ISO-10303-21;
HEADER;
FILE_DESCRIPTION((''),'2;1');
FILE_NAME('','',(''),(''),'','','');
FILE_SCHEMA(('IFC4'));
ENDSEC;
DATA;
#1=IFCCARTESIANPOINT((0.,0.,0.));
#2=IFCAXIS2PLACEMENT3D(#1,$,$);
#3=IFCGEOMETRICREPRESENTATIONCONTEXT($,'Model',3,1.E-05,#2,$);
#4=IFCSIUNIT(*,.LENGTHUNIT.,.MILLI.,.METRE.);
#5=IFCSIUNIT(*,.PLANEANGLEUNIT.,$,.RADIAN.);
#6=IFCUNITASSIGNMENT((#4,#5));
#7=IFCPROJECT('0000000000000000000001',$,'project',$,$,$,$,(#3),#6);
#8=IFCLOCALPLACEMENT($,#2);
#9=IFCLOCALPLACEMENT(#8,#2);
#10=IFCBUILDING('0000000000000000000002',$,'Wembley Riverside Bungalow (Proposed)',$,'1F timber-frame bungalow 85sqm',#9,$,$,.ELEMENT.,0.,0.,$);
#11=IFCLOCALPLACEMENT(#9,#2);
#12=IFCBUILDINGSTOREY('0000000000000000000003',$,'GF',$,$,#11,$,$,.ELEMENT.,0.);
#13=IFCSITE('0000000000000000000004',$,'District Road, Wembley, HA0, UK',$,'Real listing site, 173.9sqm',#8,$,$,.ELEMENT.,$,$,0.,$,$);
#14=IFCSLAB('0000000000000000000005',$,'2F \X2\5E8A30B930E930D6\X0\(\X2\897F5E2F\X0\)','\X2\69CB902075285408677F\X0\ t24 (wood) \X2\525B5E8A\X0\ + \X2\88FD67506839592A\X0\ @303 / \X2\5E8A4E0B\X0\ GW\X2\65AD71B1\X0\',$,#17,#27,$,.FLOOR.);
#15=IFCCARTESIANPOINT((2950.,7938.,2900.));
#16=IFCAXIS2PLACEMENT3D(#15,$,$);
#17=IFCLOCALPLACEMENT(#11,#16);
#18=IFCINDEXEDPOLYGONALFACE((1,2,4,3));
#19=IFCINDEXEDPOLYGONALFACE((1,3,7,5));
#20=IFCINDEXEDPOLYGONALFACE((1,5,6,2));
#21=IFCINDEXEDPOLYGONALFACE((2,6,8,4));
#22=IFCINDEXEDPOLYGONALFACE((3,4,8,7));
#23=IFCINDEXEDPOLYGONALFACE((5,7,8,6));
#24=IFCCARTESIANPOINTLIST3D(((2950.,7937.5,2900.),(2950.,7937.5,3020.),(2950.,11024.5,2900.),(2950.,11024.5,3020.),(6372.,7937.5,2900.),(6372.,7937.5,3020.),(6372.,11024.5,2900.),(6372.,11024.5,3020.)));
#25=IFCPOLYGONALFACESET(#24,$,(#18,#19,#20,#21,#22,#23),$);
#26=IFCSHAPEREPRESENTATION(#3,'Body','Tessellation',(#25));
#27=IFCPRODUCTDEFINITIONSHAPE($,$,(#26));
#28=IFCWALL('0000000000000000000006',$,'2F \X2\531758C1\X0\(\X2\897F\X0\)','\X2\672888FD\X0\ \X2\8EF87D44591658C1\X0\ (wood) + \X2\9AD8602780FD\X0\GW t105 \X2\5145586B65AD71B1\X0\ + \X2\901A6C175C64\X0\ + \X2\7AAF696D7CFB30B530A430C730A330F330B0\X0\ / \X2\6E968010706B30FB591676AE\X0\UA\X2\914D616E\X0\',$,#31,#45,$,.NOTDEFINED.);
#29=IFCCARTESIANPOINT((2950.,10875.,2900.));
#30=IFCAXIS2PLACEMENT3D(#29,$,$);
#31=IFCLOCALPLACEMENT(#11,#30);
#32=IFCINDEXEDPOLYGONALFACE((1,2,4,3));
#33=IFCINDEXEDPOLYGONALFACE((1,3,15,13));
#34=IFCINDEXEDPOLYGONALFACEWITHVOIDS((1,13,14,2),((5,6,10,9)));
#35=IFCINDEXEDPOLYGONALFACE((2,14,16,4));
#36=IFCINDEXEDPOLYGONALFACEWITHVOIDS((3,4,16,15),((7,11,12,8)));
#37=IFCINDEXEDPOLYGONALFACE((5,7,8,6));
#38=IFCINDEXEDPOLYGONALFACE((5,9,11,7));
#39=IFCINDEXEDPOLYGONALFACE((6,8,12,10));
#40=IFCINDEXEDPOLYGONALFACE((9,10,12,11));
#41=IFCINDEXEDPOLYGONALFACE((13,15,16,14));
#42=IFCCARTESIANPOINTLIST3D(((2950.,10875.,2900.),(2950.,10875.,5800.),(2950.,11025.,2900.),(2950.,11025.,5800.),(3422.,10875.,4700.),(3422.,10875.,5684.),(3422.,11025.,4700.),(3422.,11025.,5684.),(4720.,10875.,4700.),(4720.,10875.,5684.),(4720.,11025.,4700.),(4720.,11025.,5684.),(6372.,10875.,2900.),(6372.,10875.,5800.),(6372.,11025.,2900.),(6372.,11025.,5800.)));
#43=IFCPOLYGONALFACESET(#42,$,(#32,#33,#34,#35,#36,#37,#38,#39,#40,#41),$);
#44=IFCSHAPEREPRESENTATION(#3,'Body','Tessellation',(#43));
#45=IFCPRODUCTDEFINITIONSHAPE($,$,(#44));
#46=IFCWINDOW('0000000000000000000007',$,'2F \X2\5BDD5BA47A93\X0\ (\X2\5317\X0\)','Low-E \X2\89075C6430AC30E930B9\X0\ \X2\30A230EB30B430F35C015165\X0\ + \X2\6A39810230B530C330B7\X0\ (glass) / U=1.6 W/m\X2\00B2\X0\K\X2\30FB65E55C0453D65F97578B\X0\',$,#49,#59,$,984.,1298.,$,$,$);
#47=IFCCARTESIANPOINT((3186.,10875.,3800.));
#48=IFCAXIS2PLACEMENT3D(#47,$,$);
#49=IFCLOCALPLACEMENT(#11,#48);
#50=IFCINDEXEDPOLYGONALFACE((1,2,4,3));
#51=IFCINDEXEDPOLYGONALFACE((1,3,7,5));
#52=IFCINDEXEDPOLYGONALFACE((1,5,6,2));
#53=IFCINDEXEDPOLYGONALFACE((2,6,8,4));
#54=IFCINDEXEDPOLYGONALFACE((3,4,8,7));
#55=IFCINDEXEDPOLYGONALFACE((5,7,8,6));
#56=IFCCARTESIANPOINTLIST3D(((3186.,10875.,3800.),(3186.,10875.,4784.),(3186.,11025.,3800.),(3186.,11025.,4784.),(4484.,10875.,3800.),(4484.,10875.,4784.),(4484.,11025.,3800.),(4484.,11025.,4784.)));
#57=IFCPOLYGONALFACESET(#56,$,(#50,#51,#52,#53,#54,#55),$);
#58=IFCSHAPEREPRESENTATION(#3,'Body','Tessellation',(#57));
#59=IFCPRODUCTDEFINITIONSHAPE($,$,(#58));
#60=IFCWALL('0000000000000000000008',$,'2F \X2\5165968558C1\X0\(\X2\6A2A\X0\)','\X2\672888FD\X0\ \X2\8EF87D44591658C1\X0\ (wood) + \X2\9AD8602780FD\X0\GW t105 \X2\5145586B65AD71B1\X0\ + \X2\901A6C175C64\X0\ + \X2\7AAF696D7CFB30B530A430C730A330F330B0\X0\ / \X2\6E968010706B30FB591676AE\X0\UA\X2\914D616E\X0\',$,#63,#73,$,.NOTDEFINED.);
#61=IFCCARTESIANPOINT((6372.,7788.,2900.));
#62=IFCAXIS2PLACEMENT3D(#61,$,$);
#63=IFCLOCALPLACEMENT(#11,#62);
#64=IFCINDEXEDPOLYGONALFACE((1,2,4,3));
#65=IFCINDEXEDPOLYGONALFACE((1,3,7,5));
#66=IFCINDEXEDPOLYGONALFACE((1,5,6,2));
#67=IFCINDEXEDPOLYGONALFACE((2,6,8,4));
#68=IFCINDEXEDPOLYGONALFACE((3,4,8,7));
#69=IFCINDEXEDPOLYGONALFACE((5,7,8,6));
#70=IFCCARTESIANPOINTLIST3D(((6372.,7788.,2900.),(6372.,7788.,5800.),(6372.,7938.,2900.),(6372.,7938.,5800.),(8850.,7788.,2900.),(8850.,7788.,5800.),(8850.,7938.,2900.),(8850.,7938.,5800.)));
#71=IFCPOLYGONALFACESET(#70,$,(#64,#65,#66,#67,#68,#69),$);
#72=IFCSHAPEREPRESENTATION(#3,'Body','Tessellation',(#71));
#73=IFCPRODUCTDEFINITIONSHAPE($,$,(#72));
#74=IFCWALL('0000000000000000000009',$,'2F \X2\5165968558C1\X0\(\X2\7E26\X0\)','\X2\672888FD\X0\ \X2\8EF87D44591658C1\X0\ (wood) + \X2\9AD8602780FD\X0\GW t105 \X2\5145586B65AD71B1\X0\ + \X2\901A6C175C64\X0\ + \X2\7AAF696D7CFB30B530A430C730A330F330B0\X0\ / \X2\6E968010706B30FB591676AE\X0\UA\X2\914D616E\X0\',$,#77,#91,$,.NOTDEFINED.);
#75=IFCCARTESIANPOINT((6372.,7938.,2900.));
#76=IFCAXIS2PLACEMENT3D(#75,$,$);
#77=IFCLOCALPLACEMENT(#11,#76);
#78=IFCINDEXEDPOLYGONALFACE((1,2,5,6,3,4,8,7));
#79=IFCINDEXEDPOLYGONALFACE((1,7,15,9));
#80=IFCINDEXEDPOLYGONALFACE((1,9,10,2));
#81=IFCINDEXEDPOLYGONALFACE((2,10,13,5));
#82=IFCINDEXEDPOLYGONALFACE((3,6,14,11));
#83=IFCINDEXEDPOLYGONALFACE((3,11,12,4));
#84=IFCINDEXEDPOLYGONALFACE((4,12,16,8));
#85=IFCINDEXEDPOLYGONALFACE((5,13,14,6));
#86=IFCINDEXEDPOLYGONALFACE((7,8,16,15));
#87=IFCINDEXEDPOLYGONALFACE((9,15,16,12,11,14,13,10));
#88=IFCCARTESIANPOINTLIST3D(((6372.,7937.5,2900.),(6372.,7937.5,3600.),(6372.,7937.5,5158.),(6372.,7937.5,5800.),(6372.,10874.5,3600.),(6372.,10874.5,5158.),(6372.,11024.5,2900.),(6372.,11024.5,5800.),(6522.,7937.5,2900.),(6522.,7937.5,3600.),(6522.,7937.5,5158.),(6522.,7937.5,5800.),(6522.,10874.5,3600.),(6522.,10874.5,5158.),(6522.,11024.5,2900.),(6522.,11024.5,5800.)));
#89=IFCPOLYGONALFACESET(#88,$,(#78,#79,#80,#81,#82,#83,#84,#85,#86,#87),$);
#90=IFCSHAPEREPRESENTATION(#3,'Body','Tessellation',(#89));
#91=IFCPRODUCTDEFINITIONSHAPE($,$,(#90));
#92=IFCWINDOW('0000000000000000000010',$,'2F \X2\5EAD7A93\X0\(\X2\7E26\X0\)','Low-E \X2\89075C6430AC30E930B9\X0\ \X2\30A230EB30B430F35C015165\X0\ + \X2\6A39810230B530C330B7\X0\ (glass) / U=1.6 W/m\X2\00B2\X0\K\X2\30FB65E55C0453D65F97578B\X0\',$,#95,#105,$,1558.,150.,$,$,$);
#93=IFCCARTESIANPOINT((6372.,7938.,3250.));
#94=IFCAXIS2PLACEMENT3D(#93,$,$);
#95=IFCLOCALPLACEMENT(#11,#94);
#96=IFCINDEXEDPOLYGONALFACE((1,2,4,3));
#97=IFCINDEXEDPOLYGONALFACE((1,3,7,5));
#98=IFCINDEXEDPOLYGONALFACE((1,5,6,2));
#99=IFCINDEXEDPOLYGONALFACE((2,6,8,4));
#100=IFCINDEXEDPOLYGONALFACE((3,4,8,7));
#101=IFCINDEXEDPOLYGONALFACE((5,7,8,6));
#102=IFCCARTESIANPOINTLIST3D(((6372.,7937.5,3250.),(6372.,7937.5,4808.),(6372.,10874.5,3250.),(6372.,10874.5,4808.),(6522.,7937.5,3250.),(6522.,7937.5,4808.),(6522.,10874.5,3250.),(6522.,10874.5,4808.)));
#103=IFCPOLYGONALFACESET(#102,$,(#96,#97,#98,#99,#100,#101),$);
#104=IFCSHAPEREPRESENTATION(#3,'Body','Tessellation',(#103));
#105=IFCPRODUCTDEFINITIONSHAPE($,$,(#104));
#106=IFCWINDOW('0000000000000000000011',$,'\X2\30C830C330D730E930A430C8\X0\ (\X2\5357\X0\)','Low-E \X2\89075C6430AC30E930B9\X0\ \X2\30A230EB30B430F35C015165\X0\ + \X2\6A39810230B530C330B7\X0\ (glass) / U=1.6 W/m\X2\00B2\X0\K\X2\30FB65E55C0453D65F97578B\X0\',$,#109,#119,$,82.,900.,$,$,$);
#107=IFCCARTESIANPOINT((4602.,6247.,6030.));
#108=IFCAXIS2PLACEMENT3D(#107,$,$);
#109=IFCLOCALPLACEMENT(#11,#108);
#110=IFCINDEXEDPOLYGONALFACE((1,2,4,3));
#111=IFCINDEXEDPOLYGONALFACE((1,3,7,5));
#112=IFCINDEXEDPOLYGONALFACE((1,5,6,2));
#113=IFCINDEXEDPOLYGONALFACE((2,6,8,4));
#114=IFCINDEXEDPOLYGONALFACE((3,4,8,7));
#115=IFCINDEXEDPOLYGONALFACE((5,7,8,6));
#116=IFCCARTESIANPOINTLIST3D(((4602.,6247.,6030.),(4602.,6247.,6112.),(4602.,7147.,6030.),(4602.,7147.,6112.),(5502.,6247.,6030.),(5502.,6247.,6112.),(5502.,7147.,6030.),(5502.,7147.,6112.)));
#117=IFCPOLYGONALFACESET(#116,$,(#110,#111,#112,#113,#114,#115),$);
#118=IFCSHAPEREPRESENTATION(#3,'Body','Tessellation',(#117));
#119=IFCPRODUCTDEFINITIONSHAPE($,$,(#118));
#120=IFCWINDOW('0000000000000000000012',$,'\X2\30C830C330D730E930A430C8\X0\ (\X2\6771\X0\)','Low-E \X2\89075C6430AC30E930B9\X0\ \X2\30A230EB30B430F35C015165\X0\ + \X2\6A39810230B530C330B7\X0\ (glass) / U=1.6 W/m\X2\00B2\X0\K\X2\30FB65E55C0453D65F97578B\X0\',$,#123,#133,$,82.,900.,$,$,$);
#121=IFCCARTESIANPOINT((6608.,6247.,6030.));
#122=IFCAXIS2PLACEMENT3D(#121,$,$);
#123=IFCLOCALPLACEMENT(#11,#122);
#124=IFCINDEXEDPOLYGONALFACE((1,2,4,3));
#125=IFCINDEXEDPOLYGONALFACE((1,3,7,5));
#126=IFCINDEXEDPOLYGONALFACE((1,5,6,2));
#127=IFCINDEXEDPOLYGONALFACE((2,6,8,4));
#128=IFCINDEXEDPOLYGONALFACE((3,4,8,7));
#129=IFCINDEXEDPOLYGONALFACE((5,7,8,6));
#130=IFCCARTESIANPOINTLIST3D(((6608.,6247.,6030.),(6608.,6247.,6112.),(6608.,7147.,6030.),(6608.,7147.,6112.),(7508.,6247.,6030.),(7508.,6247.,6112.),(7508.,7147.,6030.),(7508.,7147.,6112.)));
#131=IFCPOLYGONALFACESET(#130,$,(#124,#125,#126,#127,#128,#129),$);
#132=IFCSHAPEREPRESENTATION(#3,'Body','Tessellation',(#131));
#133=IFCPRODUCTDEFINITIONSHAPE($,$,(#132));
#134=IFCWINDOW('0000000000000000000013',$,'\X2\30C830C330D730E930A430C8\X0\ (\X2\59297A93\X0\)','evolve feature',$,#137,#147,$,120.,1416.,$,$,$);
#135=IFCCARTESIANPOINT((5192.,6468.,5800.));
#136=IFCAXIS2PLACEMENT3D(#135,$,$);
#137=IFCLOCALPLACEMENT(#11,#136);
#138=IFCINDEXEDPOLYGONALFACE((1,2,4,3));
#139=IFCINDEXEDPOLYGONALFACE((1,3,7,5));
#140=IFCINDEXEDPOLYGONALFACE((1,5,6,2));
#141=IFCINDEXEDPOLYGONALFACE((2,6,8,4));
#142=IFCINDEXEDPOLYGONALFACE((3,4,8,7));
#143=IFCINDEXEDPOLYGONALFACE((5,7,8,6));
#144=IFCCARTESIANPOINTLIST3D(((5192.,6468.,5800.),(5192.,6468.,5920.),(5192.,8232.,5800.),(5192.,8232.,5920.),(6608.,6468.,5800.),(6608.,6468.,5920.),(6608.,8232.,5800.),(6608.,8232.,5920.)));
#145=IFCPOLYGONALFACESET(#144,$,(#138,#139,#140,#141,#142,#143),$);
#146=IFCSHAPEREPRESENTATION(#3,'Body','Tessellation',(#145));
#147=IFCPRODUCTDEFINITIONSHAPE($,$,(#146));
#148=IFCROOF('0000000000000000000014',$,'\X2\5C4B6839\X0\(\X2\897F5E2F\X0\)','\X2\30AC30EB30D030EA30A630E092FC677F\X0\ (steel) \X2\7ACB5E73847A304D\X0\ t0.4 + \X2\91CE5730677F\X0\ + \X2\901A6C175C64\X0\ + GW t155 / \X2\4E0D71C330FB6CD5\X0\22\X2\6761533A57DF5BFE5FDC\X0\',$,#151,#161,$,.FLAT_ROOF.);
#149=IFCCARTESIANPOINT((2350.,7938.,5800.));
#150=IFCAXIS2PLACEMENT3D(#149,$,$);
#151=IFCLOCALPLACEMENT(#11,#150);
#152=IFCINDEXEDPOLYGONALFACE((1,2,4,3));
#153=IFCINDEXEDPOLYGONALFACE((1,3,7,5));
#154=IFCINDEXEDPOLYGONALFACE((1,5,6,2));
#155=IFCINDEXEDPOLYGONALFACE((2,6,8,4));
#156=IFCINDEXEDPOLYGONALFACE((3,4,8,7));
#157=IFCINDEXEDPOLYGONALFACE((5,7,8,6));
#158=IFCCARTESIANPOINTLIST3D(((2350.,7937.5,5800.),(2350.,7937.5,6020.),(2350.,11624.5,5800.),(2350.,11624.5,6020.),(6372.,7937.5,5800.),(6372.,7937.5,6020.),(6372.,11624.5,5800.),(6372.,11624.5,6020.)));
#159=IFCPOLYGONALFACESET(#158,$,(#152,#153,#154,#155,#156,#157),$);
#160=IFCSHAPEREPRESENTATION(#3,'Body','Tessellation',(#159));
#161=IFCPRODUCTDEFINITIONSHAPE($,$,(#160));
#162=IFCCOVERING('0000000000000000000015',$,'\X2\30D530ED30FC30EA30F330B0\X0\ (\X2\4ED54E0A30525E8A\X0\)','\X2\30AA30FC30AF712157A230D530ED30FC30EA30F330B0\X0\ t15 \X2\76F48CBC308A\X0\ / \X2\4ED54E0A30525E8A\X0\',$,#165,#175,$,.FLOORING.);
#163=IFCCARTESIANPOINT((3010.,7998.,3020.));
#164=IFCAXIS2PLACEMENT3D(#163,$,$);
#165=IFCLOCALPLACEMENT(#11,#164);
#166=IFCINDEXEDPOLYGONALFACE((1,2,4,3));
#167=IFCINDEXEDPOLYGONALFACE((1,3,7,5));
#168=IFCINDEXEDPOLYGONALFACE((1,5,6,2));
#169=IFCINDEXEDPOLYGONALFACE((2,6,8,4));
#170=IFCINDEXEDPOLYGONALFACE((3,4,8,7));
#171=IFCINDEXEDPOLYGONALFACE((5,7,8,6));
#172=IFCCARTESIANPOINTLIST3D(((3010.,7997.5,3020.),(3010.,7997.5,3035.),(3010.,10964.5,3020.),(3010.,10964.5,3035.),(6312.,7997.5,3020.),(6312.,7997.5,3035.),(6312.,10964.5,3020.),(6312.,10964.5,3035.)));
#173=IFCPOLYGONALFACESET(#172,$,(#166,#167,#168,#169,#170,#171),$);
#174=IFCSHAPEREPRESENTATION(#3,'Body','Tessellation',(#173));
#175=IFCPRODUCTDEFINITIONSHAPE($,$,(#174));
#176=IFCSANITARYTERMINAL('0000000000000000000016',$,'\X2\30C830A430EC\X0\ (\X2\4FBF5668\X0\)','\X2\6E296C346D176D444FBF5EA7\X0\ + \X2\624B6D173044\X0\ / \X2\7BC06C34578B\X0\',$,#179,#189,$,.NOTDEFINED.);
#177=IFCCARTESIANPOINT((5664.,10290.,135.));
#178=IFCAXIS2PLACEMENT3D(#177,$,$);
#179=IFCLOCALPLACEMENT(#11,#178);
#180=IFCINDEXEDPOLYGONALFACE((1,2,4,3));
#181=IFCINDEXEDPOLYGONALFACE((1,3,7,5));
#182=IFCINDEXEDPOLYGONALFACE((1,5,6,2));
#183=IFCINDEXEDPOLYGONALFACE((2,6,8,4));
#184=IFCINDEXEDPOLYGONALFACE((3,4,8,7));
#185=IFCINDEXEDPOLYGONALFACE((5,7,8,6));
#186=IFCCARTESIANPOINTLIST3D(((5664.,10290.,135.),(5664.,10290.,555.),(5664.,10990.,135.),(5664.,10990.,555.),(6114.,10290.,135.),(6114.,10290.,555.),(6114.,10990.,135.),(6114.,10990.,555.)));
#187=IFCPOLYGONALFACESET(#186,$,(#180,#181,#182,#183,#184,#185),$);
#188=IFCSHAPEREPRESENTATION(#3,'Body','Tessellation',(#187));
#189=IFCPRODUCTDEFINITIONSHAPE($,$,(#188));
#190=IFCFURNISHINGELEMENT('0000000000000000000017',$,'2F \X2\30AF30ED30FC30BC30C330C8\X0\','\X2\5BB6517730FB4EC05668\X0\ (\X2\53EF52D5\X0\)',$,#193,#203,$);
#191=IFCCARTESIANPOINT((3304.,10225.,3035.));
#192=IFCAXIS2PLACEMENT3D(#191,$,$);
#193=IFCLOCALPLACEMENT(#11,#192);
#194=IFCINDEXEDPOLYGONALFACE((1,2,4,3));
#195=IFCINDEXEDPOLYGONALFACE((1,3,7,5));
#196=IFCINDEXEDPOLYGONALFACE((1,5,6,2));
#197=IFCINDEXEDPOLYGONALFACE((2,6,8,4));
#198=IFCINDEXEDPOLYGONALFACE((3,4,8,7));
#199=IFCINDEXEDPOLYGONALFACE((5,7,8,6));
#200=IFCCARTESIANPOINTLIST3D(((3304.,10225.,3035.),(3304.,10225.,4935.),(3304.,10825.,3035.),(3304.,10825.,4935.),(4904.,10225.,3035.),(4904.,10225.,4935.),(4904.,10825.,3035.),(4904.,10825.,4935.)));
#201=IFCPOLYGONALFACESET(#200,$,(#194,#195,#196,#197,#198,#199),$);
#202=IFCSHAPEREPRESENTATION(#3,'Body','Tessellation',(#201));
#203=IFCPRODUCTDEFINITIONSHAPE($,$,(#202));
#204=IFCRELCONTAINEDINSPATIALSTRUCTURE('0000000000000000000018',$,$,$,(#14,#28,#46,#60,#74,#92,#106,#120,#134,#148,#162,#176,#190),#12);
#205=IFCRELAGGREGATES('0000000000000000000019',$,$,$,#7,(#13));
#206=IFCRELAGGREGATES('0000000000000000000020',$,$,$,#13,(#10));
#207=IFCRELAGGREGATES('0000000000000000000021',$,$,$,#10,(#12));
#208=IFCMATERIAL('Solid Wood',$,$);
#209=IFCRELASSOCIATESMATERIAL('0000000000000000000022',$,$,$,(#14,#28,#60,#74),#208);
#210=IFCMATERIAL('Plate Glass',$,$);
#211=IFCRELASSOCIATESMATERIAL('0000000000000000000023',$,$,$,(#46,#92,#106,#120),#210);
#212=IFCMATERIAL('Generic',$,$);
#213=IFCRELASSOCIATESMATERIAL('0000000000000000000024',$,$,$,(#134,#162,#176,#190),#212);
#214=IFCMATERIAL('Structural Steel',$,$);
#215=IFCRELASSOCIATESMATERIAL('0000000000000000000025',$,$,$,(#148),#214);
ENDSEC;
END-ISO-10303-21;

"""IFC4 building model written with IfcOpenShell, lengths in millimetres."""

from ifc_helpers import new_model, si_unit, frame, frame_2d, origin, place, context, project, spatial, rectangle, extrude, material, element, fill, save


model = new_model("IFC4")

# Units and contexts
model_context = context("Model", 3, precision=1e-05, world=origin())
ifc_project = project(units=[si_unit("LENGTHUNIT", "METRE", prefix="MILLI"), si_unit("PLANEANGLEUNIT", "RADIAN")], contexts=[model_context])

# Site, building, storey
site_placement = place(None, origin())
site = spatial("IfcSite", under=ifc_project, at=site_placement, Name="District Road, Wembley, HA0, UK", ObjectType="Real listing site, 173.9sqm", CompositionType="ELEMENT", RefElevation=0.0)
building_placement = place(site_placement, origin())
building = spatial("IfcBuilding", under=site, at=building_placement, Name="Wembley Riverside Bungalow (Proposed)", ObjectType="1F timber-frame bungalow 85sqm", CompositionType="ELEMENT", ElevationOfRefHeight=0.0, ElevationOfTerrain=0.0)
storey_placement = place(building_placement, origin())
storey = spatial("IfcBuildingStorey", under=building, at=storey_placement, Name="GF", CompositionType="ELEMENT", Elevation=0.0)

# Slab
ifc_material_1 = material(Name="Solid Wood")
slab_placement = place(storey_placement, frame((2950.0, 7938.0, 2900.0)))
element("IfcSlab", 1, at=slab_placement, inside=storey, material=ifc_material_1, Name="2F 床スラブ(西帯)", Description="構造用合板 t24 (wood) 剛床 + 製材根太 @303 / 床下 GW断熱", PredefinedType="FLOOR", context=model_context, shape_type="SweptSolid", body=[
    extrude(rectangle(XDim=3422.0, YDim=3087.0, at=frame_2d((1711.0, 1543.0))), frame((2950.0, 7938.0, 2900.0)), (0.0, 0.0, 1.0), 120.0),
])

# Wall, opening, window
wall_1_placement = place(storey_placement, frame((2950.0, 10875.0, 2900.0)))
wall_1 = element("IfcWall", 2, at=wall_1_placement, inside=storey, material=ifc_material_1, Name="2F 北壁(西)", Description="木製 軸組外壁 (wood) + 高性能GW t105 充填断熱 + 通気層 + 窯業系サイディング / 準耐火・外皮UA配慮", PredefinedType="NOTDEFINED", context=model_context, shape_type="SweptSolid", body=[
    extrude(rectangle(XDim=3422.0, YDim=150.0, at=frame_2d((1711.0, 75.0))), frame((2950.0, 10875.0, 2900.0)), (0.0, 0.0, 1.0), 2900.0),
])
opening_1_placement = place(storey_placement, frame((3186.0, 10875.0, 3800.0)))
opening_1 = element("IfcOpeningElement", 3, at=opening_1_placement, cuts=wall_1, PredefinedType="NOTDEFINED", context=model_context, shape_type="SweptSolid", body=[
    extrude(rectangle(XDim=1298.0, YDim=150.0, at=frame_2d((649.0, 75.0))), frame((3186.0, 10875.0, 3800.0)), (0.0, 0.0, 1.0), 984.0),
])
ifc_material_2 = material(Name="Plate Glass")
window_1_placement = place(storey_placement, frame((3186.0, 10875.0, 3800.0)))
window_1 = element("IfcWindow", 4, at=window_1_placement, inside=storey, material=ifc_material_2, Name="2F 寝室窓 (北)", Description="Low-E 複層ガラス アルゴン封入 + 樹脂サッシ (glass) / U=1.6 W/m²K・日射取得型", OverallHeight=984.0, OverallWidth=1298.0, context=model_context, shape_type="SweptSolid", body=[
    extrude(rectangle(XDim=1298.0, YDim=150.0, at=frame_2d((649.0, 75.0))), frame((3186.0, 10875.0, 3800.0)), (0.0, 0.0, 1.0), 984.0),
])
fill(opening_1, window_1)

# Wall
wall_2_placement = place(storey_placement, frame((6372.0, 7788.0, 2900.0)))
element("IfcWall", 5, at=wall_2_placement, inside=storey, material=ifc_material_1, Name="2F 入隅壁(横)", Description="木製 軸組外壁 (wood) + 高性能GW t105 充填断熱 + 通気層 + 窯業系サイディング / 準耐火・外皮UA配慮", PredefinedType="NOTDEFINED", context=model_context, shape_type="SweptSolid", body=[
    extrude(rectangle(XDim=2478.0, YDim=150.0, at=frame_2d((1239.0, 75.0))), frame((6372.0, 7788.0, 2900.0)), (0.0, 0.0, 1.0), 2900.0),
])

# Wall, opening, window
wall_3_placement = place(storey_placement, frame((6372.0, 7938.0, 2900.0)))
wall_3 = element("IfcWall", 6, at=wall_3_placement, inside=storey, material=ifc_material_1, Name="2F 入隅壁(縦)", Description="木製 軸組外壁 (wood) + 高性能GW t105 充填断熱 + 通気層 + 窯業系サイディング / 準耐火・外皮UA配慮", PredefinedType="NOTDEFINED", context=model_context, shape_type="SweptSolid", body=[
    extrude(rectangle(XDim=150.0, YDim=3087.0, at=frame_2d((75.0, 1543.0))), frame((6372.0, 7938.0, 2900.0)), (0.0, 0.0, 1.0), 2900.0),
])
opening_2_placement = place(storey_placement, frame((6372.0, 7938.0, 3250.0)))
opening_2 = element("IfcOpeningElement", 7, at=opening_2_placement, cuts=wall_3, PredefinedType="NOTDEFINED", context=model_context, shape_type="SweptSolid", body=[
    extrude(rectangle(XDim=150.0, YDim=2937.0, at=frame_2d((75.0, 1468.0))), frame((6372.0, 7938.0, 3250.0)), (0.0, 0.0, 1.0), 1558.0),
])
window_2_placement = place(storey_placement, frame((6372.0, 7938.0, 3250.0)))
window_2 = element("IfcWindow", 8, at=window_2_placement, inside=storey, material=ifc_material_2, Name="2F 庭窓(縦)", Description="Low-E 複層ガラス アルゴン封入 + 樹脂サッシ (glass) / U=1.6 W/m²K・日射取得型", OverallHeight=1558.0, OverallWidth=150.0, context=model_context, shape_type="SweptSolid", body=[
    extrude(rectangle(XDim=150.0, YDim=2937.0, at=frame_2d((75.0, 1468.0))), frame((6372.0, 7938.0, 3250.0)), (0.0, 0.0, 1.0), 1558.0),
])
fill(opening_2, window_2)

# Windows
window_3_placement = place(storey_placement, frame((4602.0, 6247.0, 6030.0)))
element("IfcWindow", 9, at=window_3_placement, inside=storey, material=ifc_material_2, Name="トップライト (南)", Description="Low-E 複層ガラス アルゴン封入 + 樹脂サッシ (glass) / U=1.6 W/m²K・日射取得型", OverallHeight=82.0, OverallWidth=900.0, context=model_context, shape_type="SweptSolid", body=[
    extrude(rectangle(XDim=900.0, YDim=900.0, at=frame_2d((450.0, 450.0))), frame((4602.0, 6247.0, 6030.0)), (0.0, 0.0, 1.0), 82.0),
])
window_4_placement = place(storey_placement, frame((6608.0, 6247.0, 6030.0)))
element("IfcWindow", 10, at=window_4_placement, inside=storey, material=ifc_material_2, Name="トップライト (東)", Description="Low-E 複層ガラス アルゴン封入 + 樹脂サッシ (glass) / U=1.6 W/m²K・日射取得型", OverallHeight=82.0, OverallWidth=900.0, context=model_context, shape_type="SweptSolid", body=[
    extrude(rectangle(XDim=900.0, YDim=900.0, at=frame_2d((450.0, 450.0))), frame((6608.0, 6247.0, 6030.0)), (0.0, 0.0, 1.0), 82.0),
])
ifc_material_3 = material(Name="Generic")
window_5_placement = place(storey_placement, frame((5192.0, 6468.0, 5800.0)))
element("IfcWindow", 11, at=window_5_placement, inside=storey, material=ifc_material_3, Name="トップライト (天窓)", Description="evolve feature", OverallHeight=120.0, OverallWidth=1416.0, context=model_context, shape_type="SweptSolid", body=[
    extrude(rectangle(XDim=1416.0, YDim=1764.0, at=frame_2d((708.0, 882.0))), frame((5192.0, 6468.0, 5800.0)), (0.0, 0.0, 1.0), 120.0),
])

# Roof
ifc_material_4 = material(Name="Structural Steel")
for number, where, name in (
    (12, (2350.0, 7938.0, 5800.0), "屋根(西帯)"),
):
    element("IfcRoof", number, at=place(storey_placement, frame(where)), inside=storey, material=ifc_material_4, Name=name, Description="ガルバリウム鋼板 (steel) 立平葺き t0.4 + 野地板 + 通気層 + GW t155 / 不燃・法22条区域対応", PredefinedType="FLAT_ROOF", context=model_context, shape_type="SweptSolid", body=[
        extrude(rectangle(XDim=4022.0, YDim=3687.0, at=frame_2d((2011.0, 1843.0))), frame((2350.0, 7938.0, 5800.0)), (0.0, 0.0, 1.0), 220.0),
    ])

# Covering
covering_placement = place(storey_placement, frame((3010.0, 7998.0, 3020.0)))
element("IfcCovering", 13, at=covering_placement, inside=storey, material=ifc_material_3, Name="フローリング (仕上げ床)", Description="オーク無垢フローリング t15 直貼り / 仕上げ床", PredefinedType="FLOORING", context=model_context, shape_type="SweptSolid", body=[
    extrude(rectangle(XDim=3302.0, YDim=2967.0, at=frame_2d((1651.0, 1483.0))), frame((3010.0, 7998.0, 3020.0)), (0.0, 0.0, 1.0), 15.0),
])

# Sanitary terminal
sanitary_terminal_placement = place(storey_placement, frame((5664.0, 10290.0, 135.0)))
element("IfcSanitaryTerminal", 14, at=sanitary_terminal_placement, inside=storey, material=ifc_material_3, Name="トイレ (便器)", Description="温水洗浄便座 + 手洗い / 節水型", PredefinedType="NOTDEFINED", context=model_context, shape_type="SweptSolid", body=[
    extrude(rectangle(XDim=450.0, YDim=700.0, at=frame_2d((225.0, 350.0))), frame((5664.0, 10290.0, 135.0)), (0.0, 0.0, 1.0), 420.0),
])

# Furnishing element
furnishing_1_placement = place(storey_placement, frame((3304.0, 10225.0, 3035.0)))
element("IfcFurnishingElement", 15, at=furnishing_1_placement, inside=storey, material=ifc_material_3, Name="2F クローゼット", Description="家具・什器 (可動)", context=model_context, shape_type="SweptSolid", body=[
    extrude(rectangle(XDim=1600.0, YDim=600.0, at=frame_2d((800.0, 300.0))), frame((3304.0, 10225.0, 3035.0)), (0.0, 0.0, 1.0), 1900.0),
])

save(model, "model.ifc")
